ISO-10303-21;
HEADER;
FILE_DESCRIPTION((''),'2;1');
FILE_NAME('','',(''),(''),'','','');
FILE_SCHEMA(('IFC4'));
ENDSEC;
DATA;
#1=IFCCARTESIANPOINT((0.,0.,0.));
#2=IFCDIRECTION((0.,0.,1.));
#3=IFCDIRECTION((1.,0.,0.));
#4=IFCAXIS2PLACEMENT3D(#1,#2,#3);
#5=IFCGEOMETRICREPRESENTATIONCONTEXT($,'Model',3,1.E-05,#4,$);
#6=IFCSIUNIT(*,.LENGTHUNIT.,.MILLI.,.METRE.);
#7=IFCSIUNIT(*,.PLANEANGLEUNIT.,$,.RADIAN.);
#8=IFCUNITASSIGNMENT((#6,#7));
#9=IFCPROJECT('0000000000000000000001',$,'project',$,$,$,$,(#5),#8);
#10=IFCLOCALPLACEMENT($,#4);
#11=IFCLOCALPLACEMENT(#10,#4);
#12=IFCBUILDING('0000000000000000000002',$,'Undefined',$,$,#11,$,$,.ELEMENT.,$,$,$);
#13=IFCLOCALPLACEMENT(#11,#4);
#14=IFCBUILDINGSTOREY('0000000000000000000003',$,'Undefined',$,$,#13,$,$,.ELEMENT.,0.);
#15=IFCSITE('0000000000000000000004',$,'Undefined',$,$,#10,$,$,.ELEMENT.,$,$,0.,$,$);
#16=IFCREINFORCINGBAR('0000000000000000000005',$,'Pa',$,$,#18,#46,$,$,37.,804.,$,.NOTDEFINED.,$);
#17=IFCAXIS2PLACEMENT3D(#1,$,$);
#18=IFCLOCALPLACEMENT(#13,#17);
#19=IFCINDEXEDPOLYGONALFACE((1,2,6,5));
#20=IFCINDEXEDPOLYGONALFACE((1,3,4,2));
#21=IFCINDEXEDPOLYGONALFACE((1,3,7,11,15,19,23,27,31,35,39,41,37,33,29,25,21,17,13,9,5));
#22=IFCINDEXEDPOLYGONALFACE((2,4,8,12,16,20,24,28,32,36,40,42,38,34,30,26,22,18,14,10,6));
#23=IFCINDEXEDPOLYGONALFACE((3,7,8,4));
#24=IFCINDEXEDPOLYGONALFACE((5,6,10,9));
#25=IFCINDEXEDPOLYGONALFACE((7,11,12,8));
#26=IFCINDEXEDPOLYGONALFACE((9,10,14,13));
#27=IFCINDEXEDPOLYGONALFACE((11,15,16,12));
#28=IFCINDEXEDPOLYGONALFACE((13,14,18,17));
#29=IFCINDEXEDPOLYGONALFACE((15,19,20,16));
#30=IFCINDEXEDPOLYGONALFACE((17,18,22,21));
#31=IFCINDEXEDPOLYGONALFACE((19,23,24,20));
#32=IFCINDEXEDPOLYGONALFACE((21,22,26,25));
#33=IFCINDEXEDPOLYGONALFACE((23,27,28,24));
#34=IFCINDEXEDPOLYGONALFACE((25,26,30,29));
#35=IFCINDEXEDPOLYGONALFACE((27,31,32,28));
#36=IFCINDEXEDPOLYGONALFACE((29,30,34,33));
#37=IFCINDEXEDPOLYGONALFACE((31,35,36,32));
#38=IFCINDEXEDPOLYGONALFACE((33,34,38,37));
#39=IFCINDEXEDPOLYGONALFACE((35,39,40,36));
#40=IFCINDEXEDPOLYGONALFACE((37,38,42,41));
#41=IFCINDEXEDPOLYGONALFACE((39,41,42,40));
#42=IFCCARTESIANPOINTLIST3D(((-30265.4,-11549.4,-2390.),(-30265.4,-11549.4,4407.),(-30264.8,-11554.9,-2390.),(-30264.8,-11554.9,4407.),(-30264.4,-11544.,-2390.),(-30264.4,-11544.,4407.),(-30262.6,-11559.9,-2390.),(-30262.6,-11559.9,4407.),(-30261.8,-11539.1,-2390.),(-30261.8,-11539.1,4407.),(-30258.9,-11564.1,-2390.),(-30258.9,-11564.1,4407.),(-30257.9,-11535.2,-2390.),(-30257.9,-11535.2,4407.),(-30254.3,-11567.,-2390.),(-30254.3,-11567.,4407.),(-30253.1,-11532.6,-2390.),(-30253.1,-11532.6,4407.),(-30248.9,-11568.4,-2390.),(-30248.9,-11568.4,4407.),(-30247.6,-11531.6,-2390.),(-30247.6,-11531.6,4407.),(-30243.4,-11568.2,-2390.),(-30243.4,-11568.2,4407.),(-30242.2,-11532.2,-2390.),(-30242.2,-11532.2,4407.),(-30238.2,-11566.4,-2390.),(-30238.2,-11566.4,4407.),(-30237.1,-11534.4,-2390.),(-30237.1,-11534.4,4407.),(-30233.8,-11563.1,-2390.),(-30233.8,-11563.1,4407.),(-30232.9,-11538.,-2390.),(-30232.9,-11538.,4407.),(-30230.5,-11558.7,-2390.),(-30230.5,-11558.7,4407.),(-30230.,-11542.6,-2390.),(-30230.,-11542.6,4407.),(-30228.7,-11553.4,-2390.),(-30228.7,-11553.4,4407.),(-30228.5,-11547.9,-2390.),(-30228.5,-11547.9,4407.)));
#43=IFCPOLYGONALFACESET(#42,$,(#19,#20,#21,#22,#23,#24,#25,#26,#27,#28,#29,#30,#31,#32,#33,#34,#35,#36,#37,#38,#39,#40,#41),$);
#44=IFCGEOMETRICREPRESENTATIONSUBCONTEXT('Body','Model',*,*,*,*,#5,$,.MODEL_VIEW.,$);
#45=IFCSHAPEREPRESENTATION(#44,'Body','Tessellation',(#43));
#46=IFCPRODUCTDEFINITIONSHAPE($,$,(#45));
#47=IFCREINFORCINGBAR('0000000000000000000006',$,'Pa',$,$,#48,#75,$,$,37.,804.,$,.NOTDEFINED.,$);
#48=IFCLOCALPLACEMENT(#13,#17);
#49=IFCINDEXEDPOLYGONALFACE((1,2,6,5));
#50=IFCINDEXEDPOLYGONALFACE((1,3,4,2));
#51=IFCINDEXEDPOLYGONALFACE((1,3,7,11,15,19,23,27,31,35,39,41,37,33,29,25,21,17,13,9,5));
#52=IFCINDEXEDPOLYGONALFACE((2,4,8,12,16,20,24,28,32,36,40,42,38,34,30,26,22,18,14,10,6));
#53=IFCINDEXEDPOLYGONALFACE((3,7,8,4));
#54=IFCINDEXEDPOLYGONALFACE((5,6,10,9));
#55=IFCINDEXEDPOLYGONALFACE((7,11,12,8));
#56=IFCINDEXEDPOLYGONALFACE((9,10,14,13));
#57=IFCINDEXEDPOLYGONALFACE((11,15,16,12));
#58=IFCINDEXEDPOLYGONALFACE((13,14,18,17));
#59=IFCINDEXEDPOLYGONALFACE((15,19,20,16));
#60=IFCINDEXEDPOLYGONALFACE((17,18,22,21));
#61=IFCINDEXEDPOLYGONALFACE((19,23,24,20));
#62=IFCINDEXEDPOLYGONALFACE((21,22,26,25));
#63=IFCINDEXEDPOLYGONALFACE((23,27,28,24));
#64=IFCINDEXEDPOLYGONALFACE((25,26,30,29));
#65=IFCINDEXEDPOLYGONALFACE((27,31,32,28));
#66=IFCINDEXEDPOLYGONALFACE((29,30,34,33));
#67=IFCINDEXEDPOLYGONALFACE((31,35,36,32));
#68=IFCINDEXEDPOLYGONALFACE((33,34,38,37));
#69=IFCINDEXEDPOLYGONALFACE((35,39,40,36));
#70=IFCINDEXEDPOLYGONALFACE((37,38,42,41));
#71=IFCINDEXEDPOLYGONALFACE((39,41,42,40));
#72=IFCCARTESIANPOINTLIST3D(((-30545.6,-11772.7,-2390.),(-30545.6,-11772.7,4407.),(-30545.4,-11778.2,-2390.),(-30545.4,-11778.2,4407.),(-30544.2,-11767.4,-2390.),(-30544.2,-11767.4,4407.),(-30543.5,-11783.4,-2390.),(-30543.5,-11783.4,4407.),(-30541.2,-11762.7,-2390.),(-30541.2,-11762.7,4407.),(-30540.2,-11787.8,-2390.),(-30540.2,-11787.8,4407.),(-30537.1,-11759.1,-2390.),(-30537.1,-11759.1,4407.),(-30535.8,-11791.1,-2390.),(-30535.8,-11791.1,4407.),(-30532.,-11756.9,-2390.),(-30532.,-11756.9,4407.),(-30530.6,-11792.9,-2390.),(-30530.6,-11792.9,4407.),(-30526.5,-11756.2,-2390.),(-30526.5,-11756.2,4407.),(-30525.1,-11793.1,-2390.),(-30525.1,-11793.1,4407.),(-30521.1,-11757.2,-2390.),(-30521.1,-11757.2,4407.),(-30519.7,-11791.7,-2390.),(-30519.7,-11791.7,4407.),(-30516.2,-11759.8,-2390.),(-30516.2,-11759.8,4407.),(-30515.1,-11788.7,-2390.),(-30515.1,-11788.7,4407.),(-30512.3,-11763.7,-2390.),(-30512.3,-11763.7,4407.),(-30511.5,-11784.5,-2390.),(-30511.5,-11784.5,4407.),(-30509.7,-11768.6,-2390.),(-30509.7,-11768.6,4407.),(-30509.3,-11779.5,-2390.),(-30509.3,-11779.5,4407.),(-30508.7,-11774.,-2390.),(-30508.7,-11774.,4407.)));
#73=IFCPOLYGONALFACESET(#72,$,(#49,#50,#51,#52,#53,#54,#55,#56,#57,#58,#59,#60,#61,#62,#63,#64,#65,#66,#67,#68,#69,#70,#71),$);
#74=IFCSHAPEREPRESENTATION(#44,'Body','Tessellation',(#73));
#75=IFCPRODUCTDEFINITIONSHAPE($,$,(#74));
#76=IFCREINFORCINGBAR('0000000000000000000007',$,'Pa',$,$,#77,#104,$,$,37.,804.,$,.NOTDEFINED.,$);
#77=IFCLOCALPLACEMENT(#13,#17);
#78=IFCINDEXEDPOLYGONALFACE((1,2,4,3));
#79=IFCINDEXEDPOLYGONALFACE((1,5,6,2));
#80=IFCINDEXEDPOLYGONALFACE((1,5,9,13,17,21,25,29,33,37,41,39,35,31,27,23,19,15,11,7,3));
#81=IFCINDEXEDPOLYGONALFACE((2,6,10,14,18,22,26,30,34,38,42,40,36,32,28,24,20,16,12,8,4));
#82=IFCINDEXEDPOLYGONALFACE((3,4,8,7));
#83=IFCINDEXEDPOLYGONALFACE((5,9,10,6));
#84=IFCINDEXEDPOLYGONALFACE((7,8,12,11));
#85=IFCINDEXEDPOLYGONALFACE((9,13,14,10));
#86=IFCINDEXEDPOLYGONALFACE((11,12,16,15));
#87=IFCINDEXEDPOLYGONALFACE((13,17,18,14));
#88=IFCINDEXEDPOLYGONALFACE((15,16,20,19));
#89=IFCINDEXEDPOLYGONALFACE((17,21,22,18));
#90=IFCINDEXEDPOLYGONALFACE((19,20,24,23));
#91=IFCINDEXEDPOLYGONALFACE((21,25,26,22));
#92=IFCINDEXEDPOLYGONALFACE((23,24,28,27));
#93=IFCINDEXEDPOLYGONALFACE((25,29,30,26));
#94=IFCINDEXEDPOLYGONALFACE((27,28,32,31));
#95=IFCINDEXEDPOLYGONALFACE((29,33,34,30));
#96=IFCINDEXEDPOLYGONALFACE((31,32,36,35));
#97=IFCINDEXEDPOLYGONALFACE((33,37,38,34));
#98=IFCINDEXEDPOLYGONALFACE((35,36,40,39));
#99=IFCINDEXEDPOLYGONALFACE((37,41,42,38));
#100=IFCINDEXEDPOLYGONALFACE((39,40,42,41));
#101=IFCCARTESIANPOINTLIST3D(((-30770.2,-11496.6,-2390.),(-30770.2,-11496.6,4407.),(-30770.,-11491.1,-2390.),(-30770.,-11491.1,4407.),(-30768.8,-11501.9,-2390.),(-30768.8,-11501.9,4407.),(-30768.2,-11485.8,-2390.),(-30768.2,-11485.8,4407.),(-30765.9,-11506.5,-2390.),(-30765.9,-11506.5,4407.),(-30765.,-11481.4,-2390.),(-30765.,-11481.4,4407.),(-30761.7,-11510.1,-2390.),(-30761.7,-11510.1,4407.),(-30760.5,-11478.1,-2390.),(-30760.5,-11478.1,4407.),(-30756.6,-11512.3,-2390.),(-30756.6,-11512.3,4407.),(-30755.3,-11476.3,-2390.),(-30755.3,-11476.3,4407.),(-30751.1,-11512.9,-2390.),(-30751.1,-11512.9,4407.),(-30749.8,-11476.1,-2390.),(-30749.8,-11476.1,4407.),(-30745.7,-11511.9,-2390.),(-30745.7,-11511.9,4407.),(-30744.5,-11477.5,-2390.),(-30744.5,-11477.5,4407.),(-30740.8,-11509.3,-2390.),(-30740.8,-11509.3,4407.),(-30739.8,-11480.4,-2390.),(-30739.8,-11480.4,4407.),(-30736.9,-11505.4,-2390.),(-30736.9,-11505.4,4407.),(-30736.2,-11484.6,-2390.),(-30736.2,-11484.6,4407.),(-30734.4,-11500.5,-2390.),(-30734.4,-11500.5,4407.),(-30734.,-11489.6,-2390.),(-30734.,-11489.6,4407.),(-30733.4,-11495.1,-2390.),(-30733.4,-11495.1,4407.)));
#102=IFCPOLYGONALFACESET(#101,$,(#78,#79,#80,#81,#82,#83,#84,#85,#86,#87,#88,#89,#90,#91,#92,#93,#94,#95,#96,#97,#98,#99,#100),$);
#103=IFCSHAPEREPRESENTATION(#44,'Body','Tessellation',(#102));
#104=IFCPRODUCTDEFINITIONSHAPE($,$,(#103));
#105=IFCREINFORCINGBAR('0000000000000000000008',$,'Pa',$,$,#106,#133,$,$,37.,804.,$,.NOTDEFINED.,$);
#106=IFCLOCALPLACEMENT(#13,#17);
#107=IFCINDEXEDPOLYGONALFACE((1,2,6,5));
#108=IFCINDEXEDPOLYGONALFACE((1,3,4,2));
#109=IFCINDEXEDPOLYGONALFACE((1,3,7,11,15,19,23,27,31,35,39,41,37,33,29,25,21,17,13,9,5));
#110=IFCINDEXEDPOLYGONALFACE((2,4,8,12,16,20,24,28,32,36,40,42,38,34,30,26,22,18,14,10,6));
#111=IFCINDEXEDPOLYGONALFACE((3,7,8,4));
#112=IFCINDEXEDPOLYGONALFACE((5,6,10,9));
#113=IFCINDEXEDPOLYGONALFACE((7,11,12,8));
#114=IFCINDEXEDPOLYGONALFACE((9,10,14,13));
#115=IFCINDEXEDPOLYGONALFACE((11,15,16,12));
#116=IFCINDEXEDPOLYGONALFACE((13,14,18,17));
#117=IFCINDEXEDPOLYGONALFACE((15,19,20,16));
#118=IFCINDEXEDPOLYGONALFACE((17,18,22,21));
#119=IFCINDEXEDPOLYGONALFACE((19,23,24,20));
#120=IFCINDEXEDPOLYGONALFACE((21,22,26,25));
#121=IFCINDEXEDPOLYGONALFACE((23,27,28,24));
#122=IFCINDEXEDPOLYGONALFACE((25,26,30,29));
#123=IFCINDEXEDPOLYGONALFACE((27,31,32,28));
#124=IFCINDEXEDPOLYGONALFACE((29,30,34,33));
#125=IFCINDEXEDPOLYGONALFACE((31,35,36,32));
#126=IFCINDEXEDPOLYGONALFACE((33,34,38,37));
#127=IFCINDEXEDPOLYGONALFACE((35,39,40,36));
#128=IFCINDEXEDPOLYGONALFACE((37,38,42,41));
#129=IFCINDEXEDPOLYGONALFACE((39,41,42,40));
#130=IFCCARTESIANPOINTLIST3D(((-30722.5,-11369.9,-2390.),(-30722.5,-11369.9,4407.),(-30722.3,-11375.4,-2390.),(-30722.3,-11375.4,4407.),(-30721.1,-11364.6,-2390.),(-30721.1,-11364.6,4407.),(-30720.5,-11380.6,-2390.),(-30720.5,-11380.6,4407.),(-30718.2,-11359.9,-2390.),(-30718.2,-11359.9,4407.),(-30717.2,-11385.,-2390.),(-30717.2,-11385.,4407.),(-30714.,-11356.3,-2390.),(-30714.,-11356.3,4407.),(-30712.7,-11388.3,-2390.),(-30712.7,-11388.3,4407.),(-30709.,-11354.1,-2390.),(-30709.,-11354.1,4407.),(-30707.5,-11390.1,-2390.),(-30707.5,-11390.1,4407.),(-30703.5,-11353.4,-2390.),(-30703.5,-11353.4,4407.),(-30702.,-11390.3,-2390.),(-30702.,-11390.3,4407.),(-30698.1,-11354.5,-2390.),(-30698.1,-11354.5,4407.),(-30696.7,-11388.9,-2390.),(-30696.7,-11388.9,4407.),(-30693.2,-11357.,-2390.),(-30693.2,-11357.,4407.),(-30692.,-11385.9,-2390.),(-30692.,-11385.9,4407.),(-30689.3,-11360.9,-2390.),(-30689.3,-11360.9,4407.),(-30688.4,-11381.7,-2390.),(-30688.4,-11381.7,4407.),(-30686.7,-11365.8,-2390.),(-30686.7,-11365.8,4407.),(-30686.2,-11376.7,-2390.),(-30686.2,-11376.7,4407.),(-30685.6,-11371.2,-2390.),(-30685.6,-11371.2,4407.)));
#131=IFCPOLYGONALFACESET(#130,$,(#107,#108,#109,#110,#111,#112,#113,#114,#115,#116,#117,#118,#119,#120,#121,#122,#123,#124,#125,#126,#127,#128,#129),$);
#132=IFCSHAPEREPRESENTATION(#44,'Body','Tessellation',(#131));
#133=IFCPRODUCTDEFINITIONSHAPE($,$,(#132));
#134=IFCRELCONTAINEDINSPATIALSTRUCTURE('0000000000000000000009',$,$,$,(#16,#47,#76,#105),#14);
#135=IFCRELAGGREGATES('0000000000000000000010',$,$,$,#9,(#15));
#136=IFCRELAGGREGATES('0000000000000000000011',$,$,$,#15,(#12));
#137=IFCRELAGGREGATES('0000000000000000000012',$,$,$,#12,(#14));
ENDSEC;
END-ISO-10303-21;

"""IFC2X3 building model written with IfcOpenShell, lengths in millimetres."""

from ifc_helpers import new_model, entity, si_unit, frame, origin_with_axes, place, context, subcontext, project, spatial, source, transform, mapped, element, save


model = new_model("IFC2X3")

# Units and contexts
model_context = context("Model", 3, precision=1e-05, world=origin_with_axes())
body_context = subcontext(model_context, "Body", "Model", "MODEL_VIEW")
ifc_project = project(units=[si_unit("LENGTHUNIT", "METRE", prefix="MILLI"), si_unit("PLANEANGLEUNIT", "RADIAN")], contexts=[model_context])

# Site, building, storey
site_placement = place(None, origin_with_axes())
site = spatial("IfcSite", under=ifc_project, at=site_placement, Name="Undefined", CompositionType="ELEMENT", RefElevation=0.0)
building_placement = place(site_placement, origin_with_axes())
building = spatial("IfcBuilding", under=site, at=building_placement, Name="Undefined", CompositionType="ELEMENT")
storey_placement = place(building_placement, origin_with_axes())
storey = spatial("IfcBuildingStorey", under=building, at=storey_placement, Name="Undefined", CompositionType="ELEMENT", Elevation=0.0)

# Reinforcing bars
shared_shape_1 = source(origin_with_axes(), body_context, "Body", "AdvancedSweptSolid", [
    entity("IfcSweptDiskSolid", entity("IfcTrimmedCurve", entity("IfcLine", entity("IfcCartesianPoint", [0.0, 0.0, 0.0]), entity("IfcVector", entity("IfcDirection", [1.0, 0.0, 0.0]), 1.0)), [entity("IfcParameterValue", 0.0)], [entity("IfcParameterValue", 6797.0)], True, "PARAMETER"), 18.5, None, 0.0, 6797.0),
])
reinforcing_bar_1_placement = place(storey_placement, frame((-30246.9, -11550.1, -2390.0), z_axis=(-0.109464, -0.993991, 0.0), x_axis=(0.0, 0.0, 1.0)))
element("IfcReinforcingBar", 1, at=reinforcing_bar_1_placement, inside=storey, Name="Pa", BarRole="NOTDEFINED", CrossSectionArea=804.0, NominalDiameter=37.0, context=body_context, shape_type="MappedRepresentation", body=[
    mapped(shared_shape_1, transform((0.0, 0.0, 0.0))),
])
shared_shape_2 = source(origin_with_axes(), body_context, "Body", "AdvancedSweptSolid", [
    entity("IfcSweptDiskSolid", entity("IfcTrimmedCurve", entity("IfcLine", entity("IfcCartesianPoint", [0.0, 0.0, 0.0]), entity("IfcVector", entity("IfcDirection", [1.0, 0.0, 0.0]), 1.0)), [entity("IfcParameterValue", 0.0)], [entity("IfcParameterValue", 6797.0)], True, "PARAMETER"), 18.5, None, 0.0, 6797.0),
])
reinforcing_bar_2_placement = place(storey_placement, frame((-30527.2, -11774.7, -2390.0), z_axis=(-0.993991, 0.109464, 0.0), x_axis=(0.0, 0.0, 1.0)))
element("IfcReinforcingBar", 2, at=reinforcing_bar_2_placement, inside=storey, Name="Pa", BarRole="NOTDEFINED", CrossSectionArea=804.0, NominalDiameter=37.0, context=body_context, shape_type="MappedRepresentation", body=[
    mapped(shared_shape_2, transform((0.0, 0.0, 0.0))),
])
shared_shape_3 = source(origin_with_axes(), body_context, "Body", "AdvancedSweptSolid", [
    entity("IfcSweptDiskSolid", entity("IfcTrimmedCurve", entity("IfcLine", entity("IfcCartesianPoint", [0.0, 0.0, 0.0]), entity("IfcVector", entity("IfcDirection", [1.0, 0.0, 0.0]), 1.0)), [entity("IfcParameterValue", 0.0)], [entity("IfcParameterValue", 6797.0)], True, "PARAMETER"), 18.5, None, 0.0, 6797.0),
])
reinforcing_bar_3_placement = place(storey_placement, frame((-30751.9, -11494.4, -2390.0), z_axis=(0.109464, 0.993991, 0.0), x_axis=(0.0, 0.0, 1.0)))
element("IfcReinforcingBar", 3, at=reinforcing_bar_3_placement, inside=storey, Name="Pa", BarRole="NOTDEFINED", CrossSectionArea=804.0, NominalDiameter=37.0, context=body_context, shape_type="MappedRepresentation", body=[
    mapped(shared_shape_3, transform((0.0, 0.0, 0.0))),
])
shared_shape_4 = source(origin_with_axes(), body_context, "Body", "AdvancedSweptSolid", [
    entity("IfcSweptDiskSolid", entity("IfcTrimmedCurve", entity("IfcLine", entity("IfcCartesianPoint", [0.0, 0.0, 0.0]), entity("IfcVector", entity("IfcDirection", [1.0, 0.0, 0.0]), 1.0)), [entity("IfcParameterValue", 0.0)], [entity("IfcParameterValue", 6797.0)], True, "PARAMETER"), 18.5, None, 0.0, 6797.0),
])
reinforcing_bar_4_placement = place(storey_placement, frame((-30704.1, -11371.9, -2390.0), z_axis=(0.591794, 0.806089, 0.0), x_axis=(0.0, 0.0, 1.0)))
element("IfcReinforcingBar", 4, at=reinforcing_bar_4_placement, inside=storey, Name="Pa", BarRole="NOTDEFINED", CrossSectionArea=804.0, NominalDiameter=37.0, context=body_context, shape_type="MappedRepresentation", body=[
    mapped(shared_shape_4, transform((0.0, 0.0, 0.0))),
])

save(model, "model.ifc")
